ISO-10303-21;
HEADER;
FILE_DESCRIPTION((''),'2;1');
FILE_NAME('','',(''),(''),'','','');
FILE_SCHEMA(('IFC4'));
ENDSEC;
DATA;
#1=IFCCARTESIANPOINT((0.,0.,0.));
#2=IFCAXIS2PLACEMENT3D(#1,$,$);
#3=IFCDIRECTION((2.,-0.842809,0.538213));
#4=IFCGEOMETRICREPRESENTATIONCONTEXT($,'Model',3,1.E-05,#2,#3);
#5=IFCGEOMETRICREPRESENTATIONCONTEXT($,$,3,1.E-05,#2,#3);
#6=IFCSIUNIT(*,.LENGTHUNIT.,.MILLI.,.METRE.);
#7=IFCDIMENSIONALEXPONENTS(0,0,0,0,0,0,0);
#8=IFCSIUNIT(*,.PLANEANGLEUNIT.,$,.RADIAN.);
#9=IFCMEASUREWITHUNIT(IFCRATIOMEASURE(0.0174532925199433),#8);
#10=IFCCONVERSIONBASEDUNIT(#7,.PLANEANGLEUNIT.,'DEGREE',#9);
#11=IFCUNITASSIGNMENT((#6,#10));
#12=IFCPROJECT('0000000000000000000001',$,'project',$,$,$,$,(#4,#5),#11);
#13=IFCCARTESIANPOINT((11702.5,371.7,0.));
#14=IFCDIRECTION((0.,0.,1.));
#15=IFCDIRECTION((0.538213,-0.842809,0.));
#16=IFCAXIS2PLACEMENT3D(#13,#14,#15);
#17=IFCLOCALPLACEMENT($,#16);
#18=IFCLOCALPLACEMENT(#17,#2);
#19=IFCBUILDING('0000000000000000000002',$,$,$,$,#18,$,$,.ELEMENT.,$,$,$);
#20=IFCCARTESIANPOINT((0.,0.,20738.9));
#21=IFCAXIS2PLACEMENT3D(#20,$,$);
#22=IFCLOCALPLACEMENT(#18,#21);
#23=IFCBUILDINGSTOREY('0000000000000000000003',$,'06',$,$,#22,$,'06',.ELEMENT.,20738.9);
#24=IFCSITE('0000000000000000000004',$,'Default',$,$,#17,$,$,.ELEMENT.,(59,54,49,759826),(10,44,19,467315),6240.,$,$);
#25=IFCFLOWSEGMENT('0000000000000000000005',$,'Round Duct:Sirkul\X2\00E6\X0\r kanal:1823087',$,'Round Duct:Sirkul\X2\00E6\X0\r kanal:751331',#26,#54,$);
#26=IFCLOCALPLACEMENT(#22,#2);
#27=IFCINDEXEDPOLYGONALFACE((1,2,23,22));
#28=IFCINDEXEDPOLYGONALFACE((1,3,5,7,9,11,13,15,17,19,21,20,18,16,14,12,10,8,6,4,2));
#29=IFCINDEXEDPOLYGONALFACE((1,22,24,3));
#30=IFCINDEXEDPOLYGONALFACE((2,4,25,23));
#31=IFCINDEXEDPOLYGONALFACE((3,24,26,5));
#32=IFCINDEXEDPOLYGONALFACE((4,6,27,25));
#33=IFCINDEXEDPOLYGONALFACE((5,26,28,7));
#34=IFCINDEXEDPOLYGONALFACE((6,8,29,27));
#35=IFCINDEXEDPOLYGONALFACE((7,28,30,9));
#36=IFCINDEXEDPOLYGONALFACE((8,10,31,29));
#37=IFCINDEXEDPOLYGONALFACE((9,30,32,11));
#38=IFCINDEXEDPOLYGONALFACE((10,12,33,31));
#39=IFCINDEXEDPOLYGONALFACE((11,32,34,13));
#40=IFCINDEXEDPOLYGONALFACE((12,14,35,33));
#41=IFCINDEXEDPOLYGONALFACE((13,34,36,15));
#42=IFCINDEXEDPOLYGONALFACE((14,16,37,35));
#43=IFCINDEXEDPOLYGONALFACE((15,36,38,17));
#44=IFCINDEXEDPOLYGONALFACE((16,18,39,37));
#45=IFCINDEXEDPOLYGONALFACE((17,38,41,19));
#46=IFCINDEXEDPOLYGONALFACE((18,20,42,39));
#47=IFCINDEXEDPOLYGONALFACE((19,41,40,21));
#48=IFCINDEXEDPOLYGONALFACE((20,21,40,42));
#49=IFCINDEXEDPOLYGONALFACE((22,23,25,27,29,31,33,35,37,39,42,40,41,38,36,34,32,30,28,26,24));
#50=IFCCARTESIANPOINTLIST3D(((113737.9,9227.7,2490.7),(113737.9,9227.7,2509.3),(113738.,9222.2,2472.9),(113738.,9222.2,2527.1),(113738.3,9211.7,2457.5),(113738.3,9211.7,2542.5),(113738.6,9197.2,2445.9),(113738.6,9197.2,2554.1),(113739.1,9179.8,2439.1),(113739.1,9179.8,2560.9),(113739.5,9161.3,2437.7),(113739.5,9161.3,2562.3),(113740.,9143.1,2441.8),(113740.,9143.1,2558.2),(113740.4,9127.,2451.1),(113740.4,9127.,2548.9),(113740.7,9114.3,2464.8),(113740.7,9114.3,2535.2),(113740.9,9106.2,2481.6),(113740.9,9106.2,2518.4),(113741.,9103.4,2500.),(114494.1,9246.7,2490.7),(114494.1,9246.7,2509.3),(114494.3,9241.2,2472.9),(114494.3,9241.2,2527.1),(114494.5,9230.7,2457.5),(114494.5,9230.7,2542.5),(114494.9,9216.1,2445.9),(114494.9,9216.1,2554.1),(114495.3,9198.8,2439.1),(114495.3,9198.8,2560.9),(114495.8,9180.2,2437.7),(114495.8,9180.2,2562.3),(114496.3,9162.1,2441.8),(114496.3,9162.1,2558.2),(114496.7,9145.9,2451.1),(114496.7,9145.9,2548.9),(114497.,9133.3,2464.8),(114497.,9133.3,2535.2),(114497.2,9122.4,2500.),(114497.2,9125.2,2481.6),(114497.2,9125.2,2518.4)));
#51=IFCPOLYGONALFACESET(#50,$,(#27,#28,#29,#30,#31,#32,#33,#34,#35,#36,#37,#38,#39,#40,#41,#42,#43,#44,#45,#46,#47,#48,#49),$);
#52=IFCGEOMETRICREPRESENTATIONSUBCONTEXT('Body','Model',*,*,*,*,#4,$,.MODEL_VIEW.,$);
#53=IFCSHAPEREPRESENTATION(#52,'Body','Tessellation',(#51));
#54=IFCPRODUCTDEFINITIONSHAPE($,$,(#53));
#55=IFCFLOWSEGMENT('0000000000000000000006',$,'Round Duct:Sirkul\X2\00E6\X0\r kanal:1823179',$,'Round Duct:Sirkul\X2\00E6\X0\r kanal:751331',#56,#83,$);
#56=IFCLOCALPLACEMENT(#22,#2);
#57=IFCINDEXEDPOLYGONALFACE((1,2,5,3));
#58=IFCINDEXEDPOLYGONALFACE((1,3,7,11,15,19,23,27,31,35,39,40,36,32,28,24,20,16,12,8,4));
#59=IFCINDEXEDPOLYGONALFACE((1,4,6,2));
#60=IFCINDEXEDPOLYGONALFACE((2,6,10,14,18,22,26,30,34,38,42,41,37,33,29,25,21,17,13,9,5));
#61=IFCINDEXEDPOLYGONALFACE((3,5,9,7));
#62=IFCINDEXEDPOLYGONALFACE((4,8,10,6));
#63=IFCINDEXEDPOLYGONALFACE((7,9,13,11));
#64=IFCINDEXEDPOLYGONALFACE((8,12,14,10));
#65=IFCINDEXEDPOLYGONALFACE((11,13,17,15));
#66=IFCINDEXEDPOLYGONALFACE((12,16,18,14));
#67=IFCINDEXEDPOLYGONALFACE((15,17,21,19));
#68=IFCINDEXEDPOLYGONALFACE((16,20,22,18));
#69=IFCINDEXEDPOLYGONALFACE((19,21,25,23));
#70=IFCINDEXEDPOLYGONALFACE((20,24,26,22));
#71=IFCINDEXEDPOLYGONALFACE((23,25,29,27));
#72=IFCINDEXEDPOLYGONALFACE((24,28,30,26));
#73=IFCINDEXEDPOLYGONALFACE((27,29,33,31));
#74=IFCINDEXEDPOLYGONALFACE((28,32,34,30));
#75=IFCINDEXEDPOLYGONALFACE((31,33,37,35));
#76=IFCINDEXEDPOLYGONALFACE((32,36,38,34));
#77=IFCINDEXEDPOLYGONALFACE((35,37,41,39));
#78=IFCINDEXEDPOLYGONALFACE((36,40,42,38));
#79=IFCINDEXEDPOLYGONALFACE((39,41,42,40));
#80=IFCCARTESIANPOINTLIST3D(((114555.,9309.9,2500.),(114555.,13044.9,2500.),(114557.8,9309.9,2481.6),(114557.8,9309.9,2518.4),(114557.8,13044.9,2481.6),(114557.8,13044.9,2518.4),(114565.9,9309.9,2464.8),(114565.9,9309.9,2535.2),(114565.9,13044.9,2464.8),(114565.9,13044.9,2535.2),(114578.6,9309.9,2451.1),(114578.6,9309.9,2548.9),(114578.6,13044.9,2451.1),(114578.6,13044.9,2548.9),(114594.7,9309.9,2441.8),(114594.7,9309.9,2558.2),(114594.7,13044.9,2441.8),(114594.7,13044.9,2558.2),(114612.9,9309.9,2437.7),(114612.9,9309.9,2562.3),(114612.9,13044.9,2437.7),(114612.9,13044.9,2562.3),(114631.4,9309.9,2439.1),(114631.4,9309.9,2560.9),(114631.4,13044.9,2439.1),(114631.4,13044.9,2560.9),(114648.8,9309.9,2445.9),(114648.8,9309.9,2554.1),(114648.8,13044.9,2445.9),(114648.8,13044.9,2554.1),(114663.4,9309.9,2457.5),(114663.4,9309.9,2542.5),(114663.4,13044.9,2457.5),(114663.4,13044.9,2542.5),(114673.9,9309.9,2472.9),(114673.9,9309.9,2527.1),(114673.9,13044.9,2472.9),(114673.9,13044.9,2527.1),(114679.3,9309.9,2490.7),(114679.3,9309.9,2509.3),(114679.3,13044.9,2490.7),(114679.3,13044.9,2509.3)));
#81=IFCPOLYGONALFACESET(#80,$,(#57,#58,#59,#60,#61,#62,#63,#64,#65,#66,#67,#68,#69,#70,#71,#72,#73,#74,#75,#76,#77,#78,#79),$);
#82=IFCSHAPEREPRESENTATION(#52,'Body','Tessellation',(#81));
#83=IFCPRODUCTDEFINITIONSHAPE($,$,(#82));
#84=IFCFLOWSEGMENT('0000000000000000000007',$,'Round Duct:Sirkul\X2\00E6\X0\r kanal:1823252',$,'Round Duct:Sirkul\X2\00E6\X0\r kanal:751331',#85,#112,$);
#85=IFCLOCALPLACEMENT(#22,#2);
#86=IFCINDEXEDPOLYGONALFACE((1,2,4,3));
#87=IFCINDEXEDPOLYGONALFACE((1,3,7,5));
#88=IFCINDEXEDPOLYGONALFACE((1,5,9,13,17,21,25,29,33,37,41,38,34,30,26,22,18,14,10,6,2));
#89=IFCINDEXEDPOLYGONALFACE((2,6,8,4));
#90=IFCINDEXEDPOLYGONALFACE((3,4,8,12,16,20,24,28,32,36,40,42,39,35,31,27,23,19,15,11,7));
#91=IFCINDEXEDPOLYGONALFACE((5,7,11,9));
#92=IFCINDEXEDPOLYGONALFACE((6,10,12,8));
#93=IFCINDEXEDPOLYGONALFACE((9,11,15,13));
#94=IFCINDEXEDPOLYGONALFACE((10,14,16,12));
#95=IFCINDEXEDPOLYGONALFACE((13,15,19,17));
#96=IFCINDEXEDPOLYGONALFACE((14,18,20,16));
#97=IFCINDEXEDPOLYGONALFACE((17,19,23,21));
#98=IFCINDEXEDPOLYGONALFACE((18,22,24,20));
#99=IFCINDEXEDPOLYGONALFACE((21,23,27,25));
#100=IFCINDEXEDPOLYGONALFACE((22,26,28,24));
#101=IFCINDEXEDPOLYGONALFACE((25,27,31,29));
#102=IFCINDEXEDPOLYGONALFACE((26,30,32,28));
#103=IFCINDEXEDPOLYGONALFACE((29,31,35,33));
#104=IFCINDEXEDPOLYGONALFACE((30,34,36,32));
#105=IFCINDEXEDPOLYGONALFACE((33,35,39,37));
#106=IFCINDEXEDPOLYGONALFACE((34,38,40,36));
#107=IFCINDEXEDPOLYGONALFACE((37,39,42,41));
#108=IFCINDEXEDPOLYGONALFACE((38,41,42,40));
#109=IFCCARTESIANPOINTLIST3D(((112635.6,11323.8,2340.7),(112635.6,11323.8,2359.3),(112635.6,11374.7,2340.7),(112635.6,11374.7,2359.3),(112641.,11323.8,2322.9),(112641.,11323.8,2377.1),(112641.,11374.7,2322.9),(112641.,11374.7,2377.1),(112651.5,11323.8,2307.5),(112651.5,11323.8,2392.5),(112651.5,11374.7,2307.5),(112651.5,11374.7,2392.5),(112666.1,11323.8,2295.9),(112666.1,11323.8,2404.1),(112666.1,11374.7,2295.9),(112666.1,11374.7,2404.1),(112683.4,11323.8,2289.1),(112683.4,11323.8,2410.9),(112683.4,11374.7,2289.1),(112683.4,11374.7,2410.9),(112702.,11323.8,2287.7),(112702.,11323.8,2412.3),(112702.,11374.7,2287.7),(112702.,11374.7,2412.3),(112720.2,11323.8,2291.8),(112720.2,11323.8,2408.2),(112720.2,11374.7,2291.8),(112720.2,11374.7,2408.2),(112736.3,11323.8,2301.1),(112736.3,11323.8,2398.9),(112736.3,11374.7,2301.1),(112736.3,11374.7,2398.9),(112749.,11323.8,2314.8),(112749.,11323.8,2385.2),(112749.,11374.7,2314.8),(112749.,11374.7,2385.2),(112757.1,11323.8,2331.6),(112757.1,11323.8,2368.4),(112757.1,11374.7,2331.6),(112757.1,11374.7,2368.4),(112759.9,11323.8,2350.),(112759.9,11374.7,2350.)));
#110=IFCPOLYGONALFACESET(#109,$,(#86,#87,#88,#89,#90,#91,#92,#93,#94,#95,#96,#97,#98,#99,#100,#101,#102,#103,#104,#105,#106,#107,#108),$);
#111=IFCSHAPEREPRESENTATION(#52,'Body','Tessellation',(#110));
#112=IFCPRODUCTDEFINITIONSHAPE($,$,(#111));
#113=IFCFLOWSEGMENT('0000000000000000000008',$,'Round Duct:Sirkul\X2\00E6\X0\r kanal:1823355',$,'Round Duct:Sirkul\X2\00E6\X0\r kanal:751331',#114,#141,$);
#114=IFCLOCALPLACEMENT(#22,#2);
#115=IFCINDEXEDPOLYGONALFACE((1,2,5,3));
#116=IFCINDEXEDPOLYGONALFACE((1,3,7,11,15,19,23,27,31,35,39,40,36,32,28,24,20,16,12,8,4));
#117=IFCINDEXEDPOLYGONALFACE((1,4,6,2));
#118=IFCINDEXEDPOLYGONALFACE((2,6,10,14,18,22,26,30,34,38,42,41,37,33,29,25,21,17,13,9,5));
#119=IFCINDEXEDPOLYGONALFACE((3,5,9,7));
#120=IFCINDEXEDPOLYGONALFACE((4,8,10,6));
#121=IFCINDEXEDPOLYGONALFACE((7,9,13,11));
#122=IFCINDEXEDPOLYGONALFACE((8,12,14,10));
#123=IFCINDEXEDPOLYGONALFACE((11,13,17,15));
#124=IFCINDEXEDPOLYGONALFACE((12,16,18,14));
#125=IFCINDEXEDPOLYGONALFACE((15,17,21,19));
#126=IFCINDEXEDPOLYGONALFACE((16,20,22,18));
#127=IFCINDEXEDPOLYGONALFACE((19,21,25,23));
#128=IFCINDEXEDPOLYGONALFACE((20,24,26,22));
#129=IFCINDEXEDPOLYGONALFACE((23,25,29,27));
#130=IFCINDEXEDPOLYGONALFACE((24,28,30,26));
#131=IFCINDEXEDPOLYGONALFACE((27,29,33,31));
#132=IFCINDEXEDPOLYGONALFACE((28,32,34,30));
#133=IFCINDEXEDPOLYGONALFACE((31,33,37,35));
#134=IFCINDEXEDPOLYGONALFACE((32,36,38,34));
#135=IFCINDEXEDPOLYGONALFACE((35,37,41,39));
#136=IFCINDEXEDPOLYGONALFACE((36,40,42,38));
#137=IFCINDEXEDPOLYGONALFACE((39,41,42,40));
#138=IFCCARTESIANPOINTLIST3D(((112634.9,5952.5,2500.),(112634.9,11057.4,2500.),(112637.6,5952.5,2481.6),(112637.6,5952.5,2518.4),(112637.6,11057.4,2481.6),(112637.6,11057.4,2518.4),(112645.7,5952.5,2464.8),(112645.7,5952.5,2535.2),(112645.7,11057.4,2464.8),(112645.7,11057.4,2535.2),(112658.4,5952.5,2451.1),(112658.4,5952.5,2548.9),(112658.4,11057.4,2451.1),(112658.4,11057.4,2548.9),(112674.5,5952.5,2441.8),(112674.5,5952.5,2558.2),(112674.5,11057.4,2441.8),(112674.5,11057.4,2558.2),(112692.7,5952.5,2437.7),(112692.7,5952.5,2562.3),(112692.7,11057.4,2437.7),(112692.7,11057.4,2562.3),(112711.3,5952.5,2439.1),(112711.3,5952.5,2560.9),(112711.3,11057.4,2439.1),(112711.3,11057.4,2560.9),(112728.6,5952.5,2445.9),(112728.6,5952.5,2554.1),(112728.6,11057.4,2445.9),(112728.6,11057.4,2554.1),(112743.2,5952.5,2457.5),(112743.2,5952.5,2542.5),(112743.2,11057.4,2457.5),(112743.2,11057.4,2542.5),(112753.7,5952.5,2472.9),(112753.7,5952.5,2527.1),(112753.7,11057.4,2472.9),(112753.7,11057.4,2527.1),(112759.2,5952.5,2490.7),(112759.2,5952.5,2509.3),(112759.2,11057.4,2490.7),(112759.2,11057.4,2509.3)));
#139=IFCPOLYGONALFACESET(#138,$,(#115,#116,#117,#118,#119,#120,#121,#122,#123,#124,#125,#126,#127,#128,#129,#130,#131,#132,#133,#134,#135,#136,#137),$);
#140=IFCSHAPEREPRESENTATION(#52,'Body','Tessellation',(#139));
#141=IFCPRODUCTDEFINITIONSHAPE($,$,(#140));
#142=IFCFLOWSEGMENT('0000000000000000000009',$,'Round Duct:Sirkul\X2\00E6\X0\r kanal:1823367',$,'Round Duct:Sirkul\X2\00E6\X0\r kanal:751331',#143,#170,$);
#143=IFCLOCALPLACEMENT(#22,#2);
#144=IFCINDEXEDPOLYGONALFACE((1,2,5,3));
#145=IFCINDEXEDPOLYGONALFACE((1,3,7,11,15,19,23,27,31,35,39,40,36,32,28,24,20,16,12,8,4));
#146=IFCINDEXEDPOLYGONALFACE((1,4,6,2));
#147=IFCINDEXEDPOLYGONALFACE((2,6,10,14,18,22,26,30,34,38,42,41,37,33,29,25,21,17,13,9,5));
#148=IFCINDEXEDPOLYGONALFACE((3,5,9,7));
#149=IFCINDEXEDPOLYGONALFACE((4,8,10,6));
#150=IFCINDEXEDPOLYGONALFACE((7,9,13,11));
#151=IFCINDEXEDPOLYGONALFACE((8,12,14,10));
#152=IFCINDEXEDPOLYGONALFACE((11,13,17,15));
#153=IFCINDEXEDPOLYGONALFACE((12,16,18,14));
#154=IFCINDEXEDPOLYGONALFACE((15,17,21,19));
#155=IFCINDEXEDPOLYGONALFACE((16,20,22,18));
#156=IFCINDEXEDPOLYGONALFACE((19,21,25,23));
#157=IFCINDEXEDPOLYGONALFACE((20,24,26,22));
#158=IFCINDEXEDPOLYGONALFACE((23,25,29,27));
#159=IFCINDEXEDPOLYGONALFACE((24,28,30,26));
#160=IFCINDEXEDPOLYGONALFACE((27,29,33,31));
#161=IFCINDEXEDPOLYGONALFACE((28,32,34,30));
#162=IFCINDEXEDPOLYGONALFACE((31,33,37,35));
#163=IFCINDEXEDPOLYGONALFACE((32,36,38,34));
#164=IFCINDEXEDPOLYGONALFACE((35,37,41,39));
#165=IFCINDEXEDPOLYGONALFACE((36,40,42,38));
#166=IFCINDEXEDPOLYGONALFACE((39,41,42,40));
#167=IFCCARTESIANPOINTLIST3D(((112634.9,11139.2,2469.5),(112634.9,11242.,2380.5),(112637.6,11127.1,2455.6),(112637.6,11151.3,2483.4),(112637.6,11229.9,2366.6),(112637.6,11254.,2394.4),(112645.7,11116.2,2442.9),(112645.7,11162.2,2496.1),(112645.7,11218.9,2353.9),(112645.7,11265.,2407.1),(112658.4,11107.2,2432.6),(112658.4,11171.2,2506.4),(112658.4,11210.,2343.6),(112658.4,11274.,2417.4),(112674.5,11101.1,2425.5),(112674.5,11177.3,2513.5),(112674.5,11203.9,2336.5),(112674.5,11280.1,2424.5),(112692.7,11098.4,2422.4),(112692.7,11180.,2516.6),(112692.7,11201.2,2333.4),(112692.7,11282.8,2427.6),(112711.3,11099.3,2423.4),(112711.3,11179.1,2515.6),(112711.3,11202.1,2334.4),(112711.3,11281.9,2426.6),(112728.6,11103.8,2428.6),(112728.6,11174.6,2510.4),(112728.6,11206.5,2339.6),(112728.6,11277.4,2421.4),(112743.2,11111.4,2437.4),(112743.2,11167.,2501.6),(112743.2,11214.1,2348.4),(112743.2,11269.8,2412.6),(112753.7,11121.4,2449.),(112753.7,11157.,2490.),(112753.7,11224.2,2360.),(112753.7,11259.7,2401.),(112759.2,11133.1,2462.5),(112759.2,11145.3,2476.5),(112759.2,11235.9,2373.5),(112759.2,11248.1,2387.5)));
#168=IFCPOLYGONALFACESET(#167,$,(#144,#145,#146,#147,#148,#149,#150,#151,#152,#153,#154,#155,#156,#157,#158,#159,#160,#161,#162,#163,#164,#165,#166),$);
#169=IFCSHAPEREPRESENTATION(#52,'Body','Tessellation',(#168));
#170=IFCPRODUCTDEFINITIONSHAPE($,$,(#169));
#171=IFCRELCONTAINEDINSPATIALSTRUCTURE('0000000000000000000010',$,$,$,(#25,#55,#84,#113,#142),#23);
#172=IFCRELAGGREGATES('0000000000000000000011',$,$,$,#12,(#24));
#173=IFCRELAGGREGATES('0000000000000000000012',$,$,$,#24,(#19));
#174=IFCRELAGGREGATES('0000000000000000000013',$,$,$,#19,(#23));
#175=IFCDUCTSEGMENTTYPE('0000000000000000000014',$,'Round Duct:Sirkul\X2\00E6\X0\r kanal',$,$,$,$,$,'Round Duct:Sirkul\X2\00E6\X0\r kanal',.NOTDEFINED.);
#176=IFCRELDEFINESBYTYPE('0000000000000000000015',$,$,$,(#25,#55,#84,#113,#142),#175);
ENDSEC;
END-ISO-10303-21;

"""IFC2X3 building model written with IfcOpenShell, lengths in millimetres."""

from ifc_helpers import new_model, entity, si_unit, converted_unit, direction, frame, frame_2d, origin, origin_2d_with_axis, place, context, subcontext, project, spatial, circle, extrude, type_object, element, save


model = new_model("IFC2X3")

# Units and contexts
model_context = context("Model", 3, precision=1e-05, world=origin(), true_north=direction((2.0, -0.842809, 0.538213)))
context_of_model = context(None, 3, precision=1e-05, world=origin(), true_north=direction((2.0, -0.842809, 0.538213)))
body_context = subcontext(model_context, "Body", "Model", "MODEL_VIEW")
ifc_project = project(units=[si_unit("LENGTHUNIT", "METRE", prefix="MILLI"), converted_unit("PLANEANGLEUNIT", "DEGREE", entity("IfcRatioMeasure", 0.0174532925199433), si_unit("PLANEANGLEUNIT", "RADIAN"), dimensions=[0, 0, 0, 0, 0, 0, 0])], contexts=[model_context, context_of_model])

# Site, building, storey
site_placement = place(None, frame((11702.5, 371.7, 0.0), z_axis=(0.0, 0.0, 1.0), x_axis=(0.538213, -0.842809, 0.0)))
site = spatial("IfcSite", under=ifc_project, at=site_placement, Name="Default", CompositionType="ELEMENT", RefLatitude=(59, 54, 49, 759826), RefLongitude=(10, 44, 19, 467315), RefElevation=6240.0)
building_placement = place(site_placement, origin())
building = spatial("IfcBuilding", under=site, at=building_placement, CompositionType="ELEMENT")
storey_placement = place(building_placement, frame((0.0, 0.0, 20738.9)))
storey = spatial("IfcBuildingStorey", under=building, at=storey_placement, Name="06", LongName="06", CompositionType="ELEMENT", Elevation=20738.9)

# Flow segments
duct_segment_type = type_object("IfcDuctSegmentType", Name="Round Duct:Sirkulær kanal", ElementType="Round Duct:Sirkulær kanal", PredefinedType="NOTDEFINED")
flow_segment_1_placement = place(storey_placement, origin())
element("IfcFlowSegment", 1, at=flow_segment_1_placement, inside=storey, type_object=duct_segment_type, Name="Round Duct:Sirkulær kanal:1823087", ObjectType="Round Duct:Sirkulær kanal:751331", context=body_context, shape_type="SweptSolid", body=[
    extrude(circle(Radius=62.5, at=origin_2d_with_axis()), frame((113739.4, 9165.9, 2500.0), z_axis=(0.999685, 0.025094, 0.0), x_axis=(0.025094, -0.999685, 0.0)), (0.0, 0.0, 1.0), 756.5),
])
flow_segment_2_placement = place(storey_placement, origin())
element("IfcFlowSegment", 2, at=flow_segment_2_placement, inside=storey, type_object=duct_segment_type, Name="Round Duct:Sirkulær kanal:1823179", ObjectType="Round Duct:Sirkulær kanal:751331", context=body_context, shape_type="SweptSolid", body=[
    extrude(circle(Radius=62.5, at=origin_2d_with_axis()), frame((114617.5, 9309.9, 2500.0), z_axis=(0.0, 1.0, 0.0), x_axis=(-1.0, 0.0, 0.0)), (0.0, 0.0, 1.0), 3735.0),
])
flow_segment_3_placement = place(storey_placement, origin())
element("IfcFlowSegment", 3, at=flow_segment_3_placement, inside=storey, type_object=duct_segment_type, Name="Round Duct:Sirkulær kanal:1823252", ObjectType="Round Duct:Sirkulær kanal:751331", context=body_context, shape_type="SweptSolid", body=[
    extrude(circle(Radius=62.5, at=origin_2d_with_axis()), frame((112697.4, 11323.8, 2350.0), z_axis=(0.0, 1.0, 0.0), x_axis=(1.0, 0.0, 0.0)), (0.0, 0.0, 1.0), 50.9),
])
flow_segment_4_placement = place(storey_placement, origin())
element("IfcFlowSegment", 4, at=flow_segment_4_placement, inside=storey, type_object=duct_segment_type, Name="Round Duct:Sirkulær kanal:1823355", ObjectType="Round Duct:Sirkulær kanal:751331", context=body_context, shape_type="SweptSolid", body=[
    extrude(circle(Radius=62.5, at=frame_2d((0.0, 0.0), x_axis=(1.0, 0.0))), frame((112697.4, 5952.5, 2500.0), z_axis=(0.0, 1.0, 0.0), x_axis=(-1.0, 0.0, 0.0)), (0.0, 0.0, 1.0), 5104.8),
])
flow_segment_5_placement = place(storey_placement, origin())
element("IfcFlowSegment", 5, at=flow_segment_5_placement, inside=storey, type_object=duct_segment_type, Name="Round Duct:Sirkulær kanal:1823367", ObjectType="Round Duct:Sirkulær kanal:751331", context=body_context, shape_type="SweptSolid", body=[
    extrude(circle(Radius=62.5, at=frame_2d((0.0, 0.0), x_axis=(1.0, 0.0))), frame((112697.4, 11139.2, 2469.5), z_axis=(0.0, 0.755963, -0.654614), x_axis=(-1.0, 0.0, 0.0)), (0.0, 0.0, 1.0), 135.9),
])

save(model, "model.ifc")
